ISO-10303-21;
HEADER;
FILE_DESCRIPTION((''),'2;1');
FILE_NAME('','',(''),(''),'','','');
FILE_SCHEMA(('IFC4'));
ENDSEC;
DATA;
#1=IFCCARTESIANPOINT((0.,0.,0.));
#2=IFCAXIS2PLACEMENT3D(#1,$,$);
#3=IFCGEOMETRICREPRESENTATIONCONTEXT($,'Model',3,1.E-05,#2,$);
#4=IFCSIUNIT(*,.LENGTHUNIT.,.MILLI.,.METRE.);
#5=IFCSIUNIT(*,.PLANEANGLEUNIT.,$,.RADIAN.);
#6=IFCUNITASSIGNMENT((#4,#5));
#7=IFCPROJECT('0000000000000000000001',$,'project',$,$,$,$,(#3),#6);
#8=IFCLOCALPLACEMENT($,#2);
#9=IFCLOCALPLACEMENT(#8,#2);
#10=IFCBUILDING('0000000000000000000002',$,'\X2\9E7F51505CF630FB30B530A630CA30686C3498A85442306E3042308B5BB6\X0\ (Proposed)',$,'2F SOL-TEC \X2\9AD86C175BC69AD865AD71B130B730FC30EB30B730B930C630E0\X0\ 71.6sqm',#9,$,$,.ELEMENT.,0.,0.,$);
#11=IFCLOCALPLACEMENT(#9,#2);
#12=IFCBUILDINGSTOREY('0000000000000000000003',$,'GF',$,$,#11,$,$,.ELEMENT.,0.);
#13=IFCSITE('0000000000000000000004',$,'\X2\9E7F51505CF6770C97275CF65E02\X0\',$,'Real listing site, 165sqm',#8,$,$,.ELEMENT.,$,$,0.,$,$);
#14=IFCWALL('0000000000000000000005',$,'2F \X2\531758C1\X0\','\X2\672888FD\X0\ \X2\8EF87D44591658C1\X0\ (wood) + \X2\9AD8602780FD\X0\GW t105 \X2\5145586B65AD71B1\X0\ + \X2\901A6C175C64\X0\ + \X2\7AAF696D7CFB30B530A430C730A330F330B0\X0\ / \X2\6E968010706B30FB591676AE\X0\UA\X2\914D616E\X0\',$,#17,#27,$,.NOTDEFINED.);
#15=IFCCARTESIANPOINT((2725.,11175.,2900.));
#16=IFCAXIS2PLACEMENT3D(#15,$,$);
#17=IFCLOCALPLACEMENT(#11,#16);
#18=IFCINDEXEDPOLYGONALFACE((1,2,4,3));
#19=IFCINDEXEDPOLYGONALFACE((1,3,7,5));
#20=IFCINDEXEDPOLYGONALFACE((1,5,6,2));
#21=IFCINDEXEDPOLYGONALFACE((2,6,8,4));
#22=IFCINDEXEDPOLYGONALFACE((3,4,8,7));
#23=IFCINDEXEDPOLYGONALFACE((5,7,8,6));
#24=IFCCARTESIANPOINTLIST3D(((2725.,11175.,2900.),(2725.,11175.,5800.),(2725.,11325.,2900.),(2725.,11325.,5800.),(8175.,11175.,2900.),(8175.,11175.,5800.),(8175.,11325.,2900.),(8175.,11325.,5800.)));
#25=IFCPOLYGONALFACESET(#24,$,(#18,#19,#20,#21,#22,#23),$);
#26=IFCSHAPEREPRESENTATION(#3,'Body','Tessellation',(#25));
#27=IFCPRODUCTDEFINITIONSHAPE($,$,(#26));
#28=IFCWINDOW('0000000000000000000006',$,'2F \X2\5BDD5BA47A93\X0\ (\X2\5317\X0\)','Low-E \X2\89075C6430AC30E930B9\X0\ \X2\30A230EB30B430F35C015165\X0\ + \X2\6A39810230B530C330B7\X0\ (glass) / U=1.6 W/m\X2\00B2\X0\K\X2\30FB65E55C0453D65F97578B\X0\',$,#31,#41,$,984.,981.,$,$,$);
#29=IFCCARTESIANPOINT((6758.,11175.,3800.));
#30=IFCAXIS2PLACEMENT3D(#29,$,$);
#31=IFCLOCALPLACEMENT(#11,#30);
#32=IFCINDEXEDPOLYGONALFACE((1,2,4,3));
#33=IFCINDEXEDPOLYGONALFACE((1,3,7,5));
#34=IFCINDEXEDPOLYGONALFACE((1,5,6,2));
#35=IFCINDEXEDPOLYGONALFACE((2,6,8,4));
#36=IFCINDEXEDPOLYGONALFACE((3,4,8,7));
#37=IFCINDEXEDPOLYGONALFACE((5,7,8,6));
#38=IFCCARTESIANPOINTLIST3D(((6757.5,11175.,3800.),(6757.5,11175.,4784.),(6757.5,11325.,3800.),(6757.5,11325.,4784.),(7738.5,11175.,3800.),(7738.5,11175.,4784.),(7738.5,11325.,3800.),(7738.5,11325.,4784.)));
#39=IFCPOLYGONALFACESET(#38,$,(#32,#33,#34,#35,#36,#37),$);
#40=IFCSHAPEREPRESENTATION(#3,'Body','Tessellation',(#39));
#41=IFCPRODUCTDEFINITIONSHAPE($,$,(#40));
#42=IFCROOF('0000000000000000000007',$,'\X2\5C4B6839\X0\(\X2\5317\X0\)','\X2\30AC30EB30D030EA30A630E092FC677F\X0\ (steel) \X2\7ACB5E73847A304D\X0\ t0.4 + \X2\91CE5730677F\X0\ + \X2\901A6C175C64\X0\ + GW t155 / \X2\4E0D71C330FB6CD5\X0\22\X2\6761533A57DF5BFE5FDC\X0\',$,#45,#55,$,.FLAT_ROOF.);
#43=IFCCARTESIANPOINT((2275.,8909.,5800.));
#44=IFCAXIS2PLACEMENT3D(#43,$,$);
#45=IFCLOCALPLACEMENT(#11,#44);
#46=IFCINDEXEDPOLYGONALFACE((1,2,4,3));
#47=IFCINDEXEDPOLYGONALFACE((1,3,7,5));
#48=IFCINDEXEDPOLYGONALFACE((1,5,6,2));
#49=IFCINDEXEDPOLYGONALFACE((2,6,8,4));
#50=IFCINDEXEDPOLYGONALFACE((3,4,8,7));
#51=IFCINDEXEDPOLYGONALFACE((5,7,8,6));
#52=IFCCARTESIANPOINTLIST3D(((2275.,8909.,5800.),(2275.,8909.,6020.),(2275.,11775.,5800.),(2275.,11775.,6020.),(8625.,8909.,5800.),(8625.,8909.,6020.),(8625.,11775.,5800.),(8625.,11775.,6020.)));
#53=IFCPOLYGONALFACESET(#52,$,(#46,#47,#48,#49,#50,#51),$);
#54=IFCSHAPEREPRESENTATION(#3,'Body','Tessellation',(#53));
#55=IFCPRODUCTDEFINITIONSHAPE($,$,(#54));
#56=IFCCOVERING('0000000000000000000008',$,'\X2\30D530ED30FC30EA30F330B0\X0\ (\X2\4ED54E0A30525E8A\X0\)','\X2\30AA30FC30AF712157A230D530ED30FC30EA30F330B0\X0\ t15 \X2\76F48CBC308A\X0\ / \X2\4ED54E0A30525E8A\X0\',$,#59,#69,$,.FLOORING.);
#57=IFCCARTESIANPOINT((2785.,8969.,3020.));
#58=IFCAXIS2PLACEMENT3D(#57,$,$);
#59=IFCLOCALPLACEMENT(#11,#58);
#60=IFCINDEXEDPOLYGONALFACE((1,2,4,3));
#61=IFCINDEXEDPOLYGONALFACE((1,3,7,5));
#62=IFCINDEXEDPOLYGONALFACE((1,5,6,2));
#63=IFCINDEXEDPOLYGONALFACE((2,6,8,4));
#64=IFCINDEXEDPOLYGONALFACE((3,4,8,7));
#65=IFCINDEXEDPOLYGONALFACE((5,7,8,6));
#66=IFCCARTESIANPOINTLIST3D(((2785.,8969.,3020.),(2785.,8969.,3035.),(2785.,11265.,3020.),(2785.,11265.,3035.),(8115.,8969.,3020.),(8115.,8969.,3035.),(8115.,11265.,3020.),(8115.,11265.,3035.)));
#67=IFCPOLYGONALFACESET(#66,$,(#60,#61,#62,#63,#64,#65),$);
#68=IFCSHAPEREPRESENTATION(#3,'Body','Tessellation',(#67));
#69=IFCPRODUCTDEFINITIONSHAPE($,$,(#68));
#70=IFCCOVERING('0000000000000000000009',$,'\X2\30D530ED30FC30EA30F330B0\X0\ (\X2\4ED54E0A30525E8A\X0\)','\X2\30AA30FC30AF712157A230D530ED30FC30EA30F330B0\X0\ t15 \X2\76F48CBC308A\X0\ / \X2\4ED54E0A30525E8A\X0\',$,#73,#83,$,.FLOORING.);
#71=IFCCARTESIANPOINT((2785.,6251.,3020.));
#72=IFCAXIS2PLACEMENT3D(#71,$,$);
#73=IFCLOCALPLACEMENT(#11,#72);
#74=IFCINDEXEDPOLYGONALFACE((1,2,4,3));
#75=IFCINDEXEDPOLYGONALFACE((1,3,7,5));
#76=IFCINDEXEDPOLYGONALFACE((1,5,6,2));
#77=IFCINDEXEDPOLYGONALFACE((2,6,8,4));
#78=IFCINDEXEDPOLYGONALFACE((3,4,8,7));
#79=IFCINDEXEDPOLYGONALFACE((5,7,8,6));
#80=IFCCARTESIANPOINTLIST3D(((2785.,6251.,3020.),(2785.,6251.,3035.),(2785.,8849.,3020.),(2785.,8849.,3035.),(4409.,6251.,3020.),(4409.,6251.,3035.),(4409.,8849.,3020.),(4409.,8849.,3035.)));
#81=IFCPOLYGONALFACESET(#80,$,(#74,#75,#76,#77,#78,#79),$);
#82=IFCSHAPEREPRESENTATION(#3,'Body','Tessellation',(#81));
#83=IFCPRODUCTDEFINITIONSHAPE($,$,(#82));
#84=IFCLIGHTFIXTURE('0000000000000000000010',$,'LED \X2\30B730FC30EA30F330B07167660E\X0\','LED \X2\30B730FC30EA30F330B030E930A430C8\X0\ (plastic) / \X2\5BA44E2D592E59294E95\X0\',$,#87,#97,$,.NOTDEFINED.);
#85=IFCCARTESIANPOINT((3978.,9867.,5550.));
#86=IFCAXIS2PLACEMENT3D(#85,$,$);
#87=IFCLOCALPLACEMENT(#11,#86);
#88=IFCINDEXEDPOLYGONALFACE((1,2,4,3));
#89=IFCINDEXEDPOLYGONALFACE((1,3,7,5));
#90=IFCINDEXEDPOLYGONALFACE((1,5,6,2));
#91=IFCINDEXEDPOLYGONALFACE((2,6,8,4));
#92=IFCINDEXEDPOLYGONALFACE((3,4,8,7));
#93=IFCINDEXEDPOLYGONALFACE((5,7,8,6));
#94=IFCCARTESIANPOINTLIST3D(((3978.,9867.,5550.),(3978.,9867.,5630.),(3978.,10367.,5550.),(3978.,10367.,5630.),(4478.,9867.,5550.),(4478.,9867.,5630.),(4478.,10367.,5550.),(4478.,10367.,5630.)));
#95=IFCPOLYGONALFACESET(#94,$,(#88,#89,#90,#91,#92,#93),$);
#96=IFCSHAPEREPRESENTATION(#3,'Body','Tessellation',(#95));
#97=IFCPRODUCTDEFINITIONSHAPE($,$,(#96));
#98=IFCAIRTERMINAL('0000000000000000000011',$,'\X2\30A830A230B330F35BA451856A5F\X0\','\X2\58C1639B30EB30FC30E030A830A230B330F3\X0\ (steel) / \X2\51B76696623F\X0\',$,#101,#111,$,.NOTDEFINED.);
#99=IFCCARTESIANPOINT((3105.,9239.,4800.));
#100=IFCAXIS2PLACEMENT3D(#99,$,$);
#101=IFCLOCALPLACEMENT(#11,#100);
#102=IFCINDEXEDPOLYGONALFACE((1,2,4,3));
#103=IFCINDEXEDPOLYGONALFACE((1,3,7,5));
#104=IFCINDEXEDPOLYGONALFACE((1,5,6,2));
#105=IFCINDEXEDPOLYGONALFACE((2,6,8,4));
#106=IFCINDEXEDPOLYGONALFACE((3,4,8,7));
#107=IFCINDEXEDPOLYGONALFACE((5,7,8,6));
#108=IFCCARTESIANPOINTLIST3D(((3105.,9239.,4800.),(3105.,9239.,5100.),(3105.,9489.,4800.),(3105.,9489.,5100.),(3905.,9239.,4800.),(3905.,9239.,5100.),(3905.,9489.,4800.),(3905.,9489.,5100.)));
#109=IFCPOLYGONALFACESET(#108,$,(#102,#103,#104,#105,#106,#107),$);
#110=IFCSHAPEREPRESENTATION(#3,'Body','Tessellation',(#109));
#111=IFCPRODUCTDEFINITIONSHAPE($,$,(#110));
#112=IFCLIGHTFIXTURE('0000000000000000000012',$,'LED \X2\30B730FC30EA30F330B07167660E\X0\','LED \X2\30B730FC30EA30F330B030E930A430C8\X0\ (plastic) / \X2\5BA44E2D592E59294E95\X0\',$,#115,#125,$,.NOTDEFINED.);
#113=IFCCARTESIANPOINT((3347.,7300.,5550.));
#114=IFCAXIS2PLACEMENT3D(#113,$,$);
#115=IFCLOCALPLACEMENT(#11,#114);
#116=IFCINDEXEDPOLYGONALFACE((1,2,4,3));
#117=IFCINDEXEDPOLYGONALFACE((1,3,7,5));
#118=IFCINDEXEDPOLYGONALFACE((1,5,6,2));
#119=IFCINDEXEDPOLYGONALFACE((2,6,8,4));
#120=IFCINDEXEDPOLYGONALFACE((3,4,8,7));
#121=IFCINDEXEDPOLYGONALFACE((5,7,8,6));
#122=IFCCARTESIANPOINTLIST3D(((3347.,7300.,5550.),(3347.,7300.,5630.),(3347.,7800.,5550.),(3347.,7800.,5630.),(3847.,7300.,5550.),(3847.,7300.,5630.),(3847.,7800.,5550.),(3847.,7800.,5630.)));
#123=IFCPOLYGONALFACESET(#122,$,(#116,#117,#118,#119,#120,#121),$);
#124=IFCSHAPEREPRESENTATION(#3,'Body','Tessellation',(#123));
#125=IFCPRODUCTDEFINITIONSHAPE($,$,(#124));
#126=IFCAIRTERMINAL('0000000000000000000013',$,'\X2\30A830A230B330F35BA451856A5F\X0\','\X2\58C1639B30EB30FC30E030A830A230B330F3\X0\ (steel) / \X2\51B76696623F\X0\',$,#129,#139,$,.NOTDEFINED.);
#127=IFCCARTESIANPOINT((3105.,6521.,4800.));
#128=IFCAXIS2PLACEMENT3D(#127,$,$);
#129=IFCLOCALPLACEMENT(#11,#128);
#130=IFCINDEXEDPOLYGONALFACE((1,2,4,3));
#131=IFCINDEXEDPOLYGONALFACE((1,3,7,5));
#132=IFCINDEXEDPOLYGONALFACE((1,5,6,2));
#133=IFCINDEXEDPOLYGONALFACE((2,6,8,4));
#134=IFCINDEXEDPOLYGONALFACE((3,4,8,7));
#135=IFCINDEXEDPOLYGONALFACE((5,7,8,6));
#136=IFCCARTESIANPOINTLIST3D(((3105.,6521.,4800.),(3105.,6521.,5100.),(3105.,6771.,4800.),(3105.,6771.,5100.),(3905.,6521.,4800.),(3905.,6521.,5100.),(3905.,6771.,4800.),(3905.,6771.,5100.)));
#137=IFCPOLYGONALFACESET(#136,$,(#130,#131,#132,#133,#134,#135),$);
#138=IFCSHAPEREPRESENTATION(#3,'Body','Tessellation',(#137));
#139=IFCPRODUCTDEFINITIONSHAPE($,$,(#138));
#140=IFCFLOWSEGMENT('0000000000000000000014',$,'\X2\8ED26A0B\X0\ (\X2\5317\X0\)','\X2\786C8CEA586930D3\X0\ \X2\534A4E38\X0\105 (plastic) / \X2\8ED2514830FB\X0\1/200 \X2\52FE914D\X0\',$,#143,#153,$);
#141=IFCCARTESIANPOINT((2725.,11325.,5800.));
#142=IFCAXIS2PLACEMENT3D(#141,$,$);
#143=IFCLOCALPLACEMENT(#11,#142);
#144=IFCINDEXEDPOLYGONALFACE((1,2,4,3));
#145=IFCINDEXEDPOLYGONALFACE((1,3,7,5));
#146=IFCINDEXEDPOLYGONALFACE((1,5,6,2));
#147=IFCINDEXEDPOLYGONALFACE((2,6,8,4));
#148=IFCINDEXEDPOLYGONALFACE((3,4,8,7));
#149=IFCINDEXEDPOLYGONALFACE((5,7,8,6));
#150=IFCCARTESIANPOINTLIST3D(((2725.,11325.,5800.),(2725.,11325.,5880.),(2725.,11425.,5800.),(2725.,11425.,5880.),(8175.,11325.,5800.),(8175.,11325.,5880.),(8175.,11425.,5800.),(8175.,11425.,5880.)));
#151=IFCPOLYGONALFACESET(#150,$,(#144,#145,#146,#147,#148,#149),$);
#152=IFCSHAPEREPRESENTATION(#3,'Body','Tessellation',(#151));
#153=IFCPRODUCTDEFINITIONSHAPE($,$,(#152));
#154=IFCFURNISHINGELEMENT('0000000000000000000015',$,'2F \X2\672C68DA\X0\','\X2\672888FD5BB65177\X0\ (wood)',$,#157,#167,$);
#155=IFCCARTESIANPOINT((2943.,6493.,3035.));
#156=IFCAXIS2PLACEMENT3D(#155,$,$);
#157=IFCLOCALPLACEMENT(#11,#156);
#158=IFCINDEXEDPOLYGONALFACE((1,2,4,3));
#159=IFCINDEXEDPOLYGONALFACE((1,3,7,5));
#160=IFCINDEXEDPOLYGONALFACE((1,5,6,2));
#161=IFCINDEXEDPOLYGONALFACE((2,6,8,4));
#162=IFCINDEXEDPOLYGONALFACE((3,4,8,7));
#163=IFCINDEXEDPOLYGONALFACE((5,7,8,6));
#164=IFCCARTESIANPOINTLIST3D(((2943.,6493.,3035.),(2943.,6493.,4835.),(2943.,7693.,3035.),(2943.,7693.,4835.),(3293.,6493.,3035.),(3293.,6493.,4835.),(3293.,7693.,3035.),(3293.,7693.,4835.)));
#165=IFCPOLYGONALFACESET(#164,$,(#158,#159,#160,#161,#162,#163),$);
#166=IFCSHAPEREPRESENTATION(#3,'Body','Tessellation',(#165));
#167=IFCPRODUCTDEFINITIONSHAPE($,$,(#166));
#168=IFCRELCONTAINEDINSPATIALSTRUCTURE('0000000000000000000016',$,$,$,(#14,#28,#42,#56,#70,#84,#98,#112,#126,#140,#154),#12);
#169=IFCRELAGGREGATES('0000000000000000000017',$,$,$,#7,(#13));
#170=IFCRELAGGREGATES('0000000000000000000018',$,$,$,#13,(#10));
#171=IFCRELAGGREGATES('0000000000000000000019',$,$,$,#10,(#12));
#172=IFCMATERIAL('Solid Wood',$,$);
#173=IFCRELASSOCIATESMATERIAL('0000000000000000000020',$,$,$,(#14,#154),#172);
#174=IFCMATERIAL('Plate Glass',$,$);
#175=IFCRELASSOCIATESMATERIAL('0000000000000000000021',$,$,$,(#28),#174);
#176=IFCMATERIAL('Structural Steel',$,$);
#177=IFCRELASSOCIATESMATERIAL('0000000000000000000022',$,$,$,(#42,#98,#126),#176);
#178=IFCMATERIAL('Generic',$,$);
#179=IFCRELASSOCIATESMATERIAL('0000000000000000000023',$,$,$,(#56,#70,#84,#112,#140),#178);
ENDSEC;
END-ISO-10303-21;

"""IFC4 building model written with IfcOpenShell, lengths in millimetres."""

from ifc_helpers import new_model, si_unit, frame, frame_2d, origin, place, context, project, spatial, rectangle, extrude, material, element, fill, save


model = new_model("IFC4")

# Units and contexts
model_context = context("Model", 3, precision=1e-05, world=origin())
ifc_project = project(units=[si_unit("LENGTHUNIT", "METRE", prefix="MILLI"), si_unit("PLANEANGLEUNIT", "RADIAN")], contexts=[model_context])

# Site, building, storey
site_placement = place(None, origin())
site = spatial("IfcSite", under=ifc_project, at=site_placement, Name="鹿児島県霧島市", ObjectType="Real listing site, 165sqm", CompositionType="ELEMENT", RefElevation=0.0)
building_placement = place(site_placement, origin())
building = spatial("IfcBuilding", under=site, at=building_placement, Name="鹿児島・サウナと水風呂のある家 (Proposed)", ObjectType="2F SOL-TEC 高気密高断熱シールシステム 71.6sqm", CompositionType="ELEMENT", ElevationOfRefHeight=0.0, ElevationOfTerrain=0.0)
storey_placement = place(building_placement, origin())
storey = spatial("IfcBuildingStorey", under=building, at=storey_placement, Name="GF", CompositionType="ELEMENT", Elevation=0.0)

# Shared definitions
ifc_material_1 = material(Name="Solid Wood")

# Wall, opening, window
wall_placement = place(storey_placement, frame((2725.0, 11175.0, 2900.0)))
wall = element("IfcWall", 1, at=wall_placement, inside=storey, material=ifc_material_1, Name="2F 北壁", Description="木製 軸組外壁 (wood) + 高性能GW t105 充填断熱 + 通気層 + 窯業系サイディング / 準耐火・外皮UA配慮", PredefinedType="NOTDEFINED", context=model_context, shape_type="SweptSolid", body=[
    extrude(rectangle(XDim=5450.0, YDim=150.0, at=frame_2d((2725.0, 75.0))), frame((2725.0, 11175.0, 2900.0)), (0.0, 0.0, 1.0), 2900.0),
])
opening_placement = place(storey_placement, frame((6758.0, 11175.0, 3800.0)))
opening = element("IfcOpeningElement", 2, at=opening_placement, cuts=wall, PredefinedType="NOTDEFINED", context=model_context, shape_type="SweptSolid", body=[
    extrude(rectangle(XDim=981.0, YDim=150.0, at=frame_2d((490.0, 75.0))), frame((6758.0, 11175.0, 3800.0)), (0.0, 0.0, 1.0), 984.0),
])
ifc_material_2 = material(Name="Plate Glass")
window_placement = place(storey_placement, frame((6758.0, 11175.0, 3800.0)))
window = element("IfcWindow", 3, at=window_placement, inside=storey, material=ifc_material_2, Name="2F 寝室窓 (北)", Description="Low-E 複層ガラス アルゴン封入 + 樹脂サッシ (glass) / U=1.6 W/m²K・日射取得型", OverallHeight=984.0, OverallWidth=981.0, context=model_context, shape_type="SweptSolid", body=[
    extrude(rectangle(XDim=981.0, YDim=150.0, at=frame_2d((490.0, 75.0))), frame((6758.0, 11175.0, 3800.0)), (0.0, 0.0, 1.0), 984.0),
])
fill(opening, window)

# Roof
ifc_material_3 = material(Name="Structural Steel")
for number, where, name in (
    (4, (2275.0, 8909.0, 5800.0), "屋根(北)"),
):
    element("IfcRoof", number, at=place(storey_placement, frame(where)), inside=storey, material=ifc_material_3, Name=name, Description="ガルバリウム鋼板 (steel) 立平葺き t0.4 + 野地板 + 通気層 + GW t155 / 不燃・法22条区域対応", PredefinedType="FLAT_ROOF", context=model_context, shape_type="SweptSolid", body=[
        extrude(rectangle(XDim=6350.0, YDim=2866.0, at=frame_2d((3175.0, 1433.0))), frame((2275.0, 8909.0, 5800.0)), (0.0, 0.0, 1.0), 220.0),
    ])

# Coverings
ifc_material_4 = material(Name="Generic")
covering_1_placement = place(storey_placement, frame((2785.0, 8969.0, 3020.0)))
element("IfcCovering", 5, at=covering_1_placement, inside=storey, material=ifc_material_4, Name="フローリング (仕上げ床)", Description="オーク無垢フローリング t15 直貼り / 仕上げ床", PredefinedType="FLOORING", context=model_context, shape_type="SweptSolid", body=[
    extrude(rectangle(XDim=5330.0, YDim=2296.0, at=frame_2d((2665.0, 1148.0))), frame((2785.0, 8969.0, 3020.0)), (0.0, 0.0, 1.0), 15.0),
])
covering_2_placement = place(storey_placement, frame((2785.0, 6251.0, 3020.0)))
element("IfcCovering", 6, at=covering_2_placement, inside=storey, material=ifc_material_4, Name="フローリング (仕上げ床)", Description="オーク無垢フローリング t15 直貼り / 仕上げ床", PredefinedType="FLOORING", context=model_context, shape_type="SweptSolid", body=[
    extrude(rectangle(XDim=1624.0, YDim=2598.0, at=frame_2d((812.0, 1299.0))), frame((2785.0, 6251.0, 3020.0)), (0.0, 0.0, 1.0), 15.0),
])

# Light fixture
light_fixture_1_placement = place(storey_placement, frame((3978.0, 9867.0, 5550.0)))
element("IfcLightFixture", 7, at=light_fixture_1_placement, inside=storey, material=ifc_material_4, Name="LED シーリング照明", Description="LED シーリングライト (plastic) / 室中央天井", PredefinedType="NOTDEFINED", context=model_context, shape_type="SweptSolid", body=[
    extrude(rectangle(XDim=500.0, YDim=500.0, at=frame_2d((250.0, 250.0))), frame((3978.0, 9867.0, 5550.0)), (0.0, 0.0, 1.0), 80.0),
])

# Air terminal
air_terminal_1_placement = place(storey_placement, frame((3105.0, 9239.0, 4800.0)))
element("IfcAirTerminal", 8, at=air_terminal_1_placement, inside=storey, material=ifc_material_3, Name="エアコン室内機", Description="壁掛ルームエアコン (steel) / 冷暖房", PredefinedType="NOTDEFINED", context=model_context, shape_type="SweptSolid", body=[
    extrude(rectangle(XDim=800.0, YDim=250.0, at=frame_2d((400.0, 125.0))), frame((3105.0, 9239.0, 4800.0)), (0.0, 0.0, 1.0), 300.0),
])

# Light fixture
light_fixture_2_placement = place(storey_placement, frame((3347.0, 7300.0, 5550.0)))
element("IfcLightFixture", 9, at=light_fixture_2_placement, inside=storey, material=ifc_material_4, Name="LED シーリング照明", Description="LED シーリングライト (plastic) / 室中央天井", PredefinedType="NOTDEFINED", context=model_context, shape_type="SweptSolid", body=[
    extrude(rectangle(XDim=500.0, YDim=500.0, at=frame_2d((250.0, 250.0))), frame((3347.0, 7300.0, 5550.0)), (0.0, 0.0, 1.0), 80.0),
])

# Air terminal
air_terminal_2_placement = place(storey_placement, frame((3105.0, 6521.0, 4800.0)))
element("IfcAirTerminal", 10, at=air_terminal_2_placement, inside=storey, material=ifc_material_3, Name="エアコン室内機", Description="壁掛ルームエアコン (steel) / 冷暖房", PredefinedType="NOTDEFINED", context=model_context, shape_type="SweptSolid", body=[
    extrude(rectangle(XDim=800.0, YDim=250.0, at=frame_2d((400.0, 125.0))), frame((3105.0, 6521.0, 4800.0)), (0.0, 0.0, 1.0), 300.0),
])

# Flow segment
flow_segment_placement = place(storey_placement, frame((2725.0, 11325.0, 5800.0)))
element("IfcFlowSegment", 11, at=flow_segment_placement, inside=storey, material=ifc_material_4, Name="軒樋 (北)", Description="硬質塩ビ 半丸105 (plastic) / 軒先・1/200 勾配", context=model_context, shape_type="SweptSolid", body=[
    extrude(rectangle(XDim=5450.0, YDim=100.0, at=frame_2d((2725.0, 50.0))), frame((2725.0, 11325.0, 5800.0)), (0.0, 0.0, 1.0), 80.0),
])

# Furnishing element
furnishing_placement = place(storey_placement, frame((2943.0, 6493.0, 3035.0)))
element("IfcFurnishingElement", 12, at=furnishing_placement, inside=storey, material=ifc_material_1, Name="2F 本棚", Description="木製家具 (wood)", context=model_context, shape_type="SweptSolid", body=[
    extrude(rectangle(XDim=350.0, YDim=1200.0, at=frame_2d((175.0, 600.0))), frame((2943.0, 6493.0, 3035.0)), (0.0, 0.0, 1.0), 1800.0),
])

save(model, "model.ifc")
